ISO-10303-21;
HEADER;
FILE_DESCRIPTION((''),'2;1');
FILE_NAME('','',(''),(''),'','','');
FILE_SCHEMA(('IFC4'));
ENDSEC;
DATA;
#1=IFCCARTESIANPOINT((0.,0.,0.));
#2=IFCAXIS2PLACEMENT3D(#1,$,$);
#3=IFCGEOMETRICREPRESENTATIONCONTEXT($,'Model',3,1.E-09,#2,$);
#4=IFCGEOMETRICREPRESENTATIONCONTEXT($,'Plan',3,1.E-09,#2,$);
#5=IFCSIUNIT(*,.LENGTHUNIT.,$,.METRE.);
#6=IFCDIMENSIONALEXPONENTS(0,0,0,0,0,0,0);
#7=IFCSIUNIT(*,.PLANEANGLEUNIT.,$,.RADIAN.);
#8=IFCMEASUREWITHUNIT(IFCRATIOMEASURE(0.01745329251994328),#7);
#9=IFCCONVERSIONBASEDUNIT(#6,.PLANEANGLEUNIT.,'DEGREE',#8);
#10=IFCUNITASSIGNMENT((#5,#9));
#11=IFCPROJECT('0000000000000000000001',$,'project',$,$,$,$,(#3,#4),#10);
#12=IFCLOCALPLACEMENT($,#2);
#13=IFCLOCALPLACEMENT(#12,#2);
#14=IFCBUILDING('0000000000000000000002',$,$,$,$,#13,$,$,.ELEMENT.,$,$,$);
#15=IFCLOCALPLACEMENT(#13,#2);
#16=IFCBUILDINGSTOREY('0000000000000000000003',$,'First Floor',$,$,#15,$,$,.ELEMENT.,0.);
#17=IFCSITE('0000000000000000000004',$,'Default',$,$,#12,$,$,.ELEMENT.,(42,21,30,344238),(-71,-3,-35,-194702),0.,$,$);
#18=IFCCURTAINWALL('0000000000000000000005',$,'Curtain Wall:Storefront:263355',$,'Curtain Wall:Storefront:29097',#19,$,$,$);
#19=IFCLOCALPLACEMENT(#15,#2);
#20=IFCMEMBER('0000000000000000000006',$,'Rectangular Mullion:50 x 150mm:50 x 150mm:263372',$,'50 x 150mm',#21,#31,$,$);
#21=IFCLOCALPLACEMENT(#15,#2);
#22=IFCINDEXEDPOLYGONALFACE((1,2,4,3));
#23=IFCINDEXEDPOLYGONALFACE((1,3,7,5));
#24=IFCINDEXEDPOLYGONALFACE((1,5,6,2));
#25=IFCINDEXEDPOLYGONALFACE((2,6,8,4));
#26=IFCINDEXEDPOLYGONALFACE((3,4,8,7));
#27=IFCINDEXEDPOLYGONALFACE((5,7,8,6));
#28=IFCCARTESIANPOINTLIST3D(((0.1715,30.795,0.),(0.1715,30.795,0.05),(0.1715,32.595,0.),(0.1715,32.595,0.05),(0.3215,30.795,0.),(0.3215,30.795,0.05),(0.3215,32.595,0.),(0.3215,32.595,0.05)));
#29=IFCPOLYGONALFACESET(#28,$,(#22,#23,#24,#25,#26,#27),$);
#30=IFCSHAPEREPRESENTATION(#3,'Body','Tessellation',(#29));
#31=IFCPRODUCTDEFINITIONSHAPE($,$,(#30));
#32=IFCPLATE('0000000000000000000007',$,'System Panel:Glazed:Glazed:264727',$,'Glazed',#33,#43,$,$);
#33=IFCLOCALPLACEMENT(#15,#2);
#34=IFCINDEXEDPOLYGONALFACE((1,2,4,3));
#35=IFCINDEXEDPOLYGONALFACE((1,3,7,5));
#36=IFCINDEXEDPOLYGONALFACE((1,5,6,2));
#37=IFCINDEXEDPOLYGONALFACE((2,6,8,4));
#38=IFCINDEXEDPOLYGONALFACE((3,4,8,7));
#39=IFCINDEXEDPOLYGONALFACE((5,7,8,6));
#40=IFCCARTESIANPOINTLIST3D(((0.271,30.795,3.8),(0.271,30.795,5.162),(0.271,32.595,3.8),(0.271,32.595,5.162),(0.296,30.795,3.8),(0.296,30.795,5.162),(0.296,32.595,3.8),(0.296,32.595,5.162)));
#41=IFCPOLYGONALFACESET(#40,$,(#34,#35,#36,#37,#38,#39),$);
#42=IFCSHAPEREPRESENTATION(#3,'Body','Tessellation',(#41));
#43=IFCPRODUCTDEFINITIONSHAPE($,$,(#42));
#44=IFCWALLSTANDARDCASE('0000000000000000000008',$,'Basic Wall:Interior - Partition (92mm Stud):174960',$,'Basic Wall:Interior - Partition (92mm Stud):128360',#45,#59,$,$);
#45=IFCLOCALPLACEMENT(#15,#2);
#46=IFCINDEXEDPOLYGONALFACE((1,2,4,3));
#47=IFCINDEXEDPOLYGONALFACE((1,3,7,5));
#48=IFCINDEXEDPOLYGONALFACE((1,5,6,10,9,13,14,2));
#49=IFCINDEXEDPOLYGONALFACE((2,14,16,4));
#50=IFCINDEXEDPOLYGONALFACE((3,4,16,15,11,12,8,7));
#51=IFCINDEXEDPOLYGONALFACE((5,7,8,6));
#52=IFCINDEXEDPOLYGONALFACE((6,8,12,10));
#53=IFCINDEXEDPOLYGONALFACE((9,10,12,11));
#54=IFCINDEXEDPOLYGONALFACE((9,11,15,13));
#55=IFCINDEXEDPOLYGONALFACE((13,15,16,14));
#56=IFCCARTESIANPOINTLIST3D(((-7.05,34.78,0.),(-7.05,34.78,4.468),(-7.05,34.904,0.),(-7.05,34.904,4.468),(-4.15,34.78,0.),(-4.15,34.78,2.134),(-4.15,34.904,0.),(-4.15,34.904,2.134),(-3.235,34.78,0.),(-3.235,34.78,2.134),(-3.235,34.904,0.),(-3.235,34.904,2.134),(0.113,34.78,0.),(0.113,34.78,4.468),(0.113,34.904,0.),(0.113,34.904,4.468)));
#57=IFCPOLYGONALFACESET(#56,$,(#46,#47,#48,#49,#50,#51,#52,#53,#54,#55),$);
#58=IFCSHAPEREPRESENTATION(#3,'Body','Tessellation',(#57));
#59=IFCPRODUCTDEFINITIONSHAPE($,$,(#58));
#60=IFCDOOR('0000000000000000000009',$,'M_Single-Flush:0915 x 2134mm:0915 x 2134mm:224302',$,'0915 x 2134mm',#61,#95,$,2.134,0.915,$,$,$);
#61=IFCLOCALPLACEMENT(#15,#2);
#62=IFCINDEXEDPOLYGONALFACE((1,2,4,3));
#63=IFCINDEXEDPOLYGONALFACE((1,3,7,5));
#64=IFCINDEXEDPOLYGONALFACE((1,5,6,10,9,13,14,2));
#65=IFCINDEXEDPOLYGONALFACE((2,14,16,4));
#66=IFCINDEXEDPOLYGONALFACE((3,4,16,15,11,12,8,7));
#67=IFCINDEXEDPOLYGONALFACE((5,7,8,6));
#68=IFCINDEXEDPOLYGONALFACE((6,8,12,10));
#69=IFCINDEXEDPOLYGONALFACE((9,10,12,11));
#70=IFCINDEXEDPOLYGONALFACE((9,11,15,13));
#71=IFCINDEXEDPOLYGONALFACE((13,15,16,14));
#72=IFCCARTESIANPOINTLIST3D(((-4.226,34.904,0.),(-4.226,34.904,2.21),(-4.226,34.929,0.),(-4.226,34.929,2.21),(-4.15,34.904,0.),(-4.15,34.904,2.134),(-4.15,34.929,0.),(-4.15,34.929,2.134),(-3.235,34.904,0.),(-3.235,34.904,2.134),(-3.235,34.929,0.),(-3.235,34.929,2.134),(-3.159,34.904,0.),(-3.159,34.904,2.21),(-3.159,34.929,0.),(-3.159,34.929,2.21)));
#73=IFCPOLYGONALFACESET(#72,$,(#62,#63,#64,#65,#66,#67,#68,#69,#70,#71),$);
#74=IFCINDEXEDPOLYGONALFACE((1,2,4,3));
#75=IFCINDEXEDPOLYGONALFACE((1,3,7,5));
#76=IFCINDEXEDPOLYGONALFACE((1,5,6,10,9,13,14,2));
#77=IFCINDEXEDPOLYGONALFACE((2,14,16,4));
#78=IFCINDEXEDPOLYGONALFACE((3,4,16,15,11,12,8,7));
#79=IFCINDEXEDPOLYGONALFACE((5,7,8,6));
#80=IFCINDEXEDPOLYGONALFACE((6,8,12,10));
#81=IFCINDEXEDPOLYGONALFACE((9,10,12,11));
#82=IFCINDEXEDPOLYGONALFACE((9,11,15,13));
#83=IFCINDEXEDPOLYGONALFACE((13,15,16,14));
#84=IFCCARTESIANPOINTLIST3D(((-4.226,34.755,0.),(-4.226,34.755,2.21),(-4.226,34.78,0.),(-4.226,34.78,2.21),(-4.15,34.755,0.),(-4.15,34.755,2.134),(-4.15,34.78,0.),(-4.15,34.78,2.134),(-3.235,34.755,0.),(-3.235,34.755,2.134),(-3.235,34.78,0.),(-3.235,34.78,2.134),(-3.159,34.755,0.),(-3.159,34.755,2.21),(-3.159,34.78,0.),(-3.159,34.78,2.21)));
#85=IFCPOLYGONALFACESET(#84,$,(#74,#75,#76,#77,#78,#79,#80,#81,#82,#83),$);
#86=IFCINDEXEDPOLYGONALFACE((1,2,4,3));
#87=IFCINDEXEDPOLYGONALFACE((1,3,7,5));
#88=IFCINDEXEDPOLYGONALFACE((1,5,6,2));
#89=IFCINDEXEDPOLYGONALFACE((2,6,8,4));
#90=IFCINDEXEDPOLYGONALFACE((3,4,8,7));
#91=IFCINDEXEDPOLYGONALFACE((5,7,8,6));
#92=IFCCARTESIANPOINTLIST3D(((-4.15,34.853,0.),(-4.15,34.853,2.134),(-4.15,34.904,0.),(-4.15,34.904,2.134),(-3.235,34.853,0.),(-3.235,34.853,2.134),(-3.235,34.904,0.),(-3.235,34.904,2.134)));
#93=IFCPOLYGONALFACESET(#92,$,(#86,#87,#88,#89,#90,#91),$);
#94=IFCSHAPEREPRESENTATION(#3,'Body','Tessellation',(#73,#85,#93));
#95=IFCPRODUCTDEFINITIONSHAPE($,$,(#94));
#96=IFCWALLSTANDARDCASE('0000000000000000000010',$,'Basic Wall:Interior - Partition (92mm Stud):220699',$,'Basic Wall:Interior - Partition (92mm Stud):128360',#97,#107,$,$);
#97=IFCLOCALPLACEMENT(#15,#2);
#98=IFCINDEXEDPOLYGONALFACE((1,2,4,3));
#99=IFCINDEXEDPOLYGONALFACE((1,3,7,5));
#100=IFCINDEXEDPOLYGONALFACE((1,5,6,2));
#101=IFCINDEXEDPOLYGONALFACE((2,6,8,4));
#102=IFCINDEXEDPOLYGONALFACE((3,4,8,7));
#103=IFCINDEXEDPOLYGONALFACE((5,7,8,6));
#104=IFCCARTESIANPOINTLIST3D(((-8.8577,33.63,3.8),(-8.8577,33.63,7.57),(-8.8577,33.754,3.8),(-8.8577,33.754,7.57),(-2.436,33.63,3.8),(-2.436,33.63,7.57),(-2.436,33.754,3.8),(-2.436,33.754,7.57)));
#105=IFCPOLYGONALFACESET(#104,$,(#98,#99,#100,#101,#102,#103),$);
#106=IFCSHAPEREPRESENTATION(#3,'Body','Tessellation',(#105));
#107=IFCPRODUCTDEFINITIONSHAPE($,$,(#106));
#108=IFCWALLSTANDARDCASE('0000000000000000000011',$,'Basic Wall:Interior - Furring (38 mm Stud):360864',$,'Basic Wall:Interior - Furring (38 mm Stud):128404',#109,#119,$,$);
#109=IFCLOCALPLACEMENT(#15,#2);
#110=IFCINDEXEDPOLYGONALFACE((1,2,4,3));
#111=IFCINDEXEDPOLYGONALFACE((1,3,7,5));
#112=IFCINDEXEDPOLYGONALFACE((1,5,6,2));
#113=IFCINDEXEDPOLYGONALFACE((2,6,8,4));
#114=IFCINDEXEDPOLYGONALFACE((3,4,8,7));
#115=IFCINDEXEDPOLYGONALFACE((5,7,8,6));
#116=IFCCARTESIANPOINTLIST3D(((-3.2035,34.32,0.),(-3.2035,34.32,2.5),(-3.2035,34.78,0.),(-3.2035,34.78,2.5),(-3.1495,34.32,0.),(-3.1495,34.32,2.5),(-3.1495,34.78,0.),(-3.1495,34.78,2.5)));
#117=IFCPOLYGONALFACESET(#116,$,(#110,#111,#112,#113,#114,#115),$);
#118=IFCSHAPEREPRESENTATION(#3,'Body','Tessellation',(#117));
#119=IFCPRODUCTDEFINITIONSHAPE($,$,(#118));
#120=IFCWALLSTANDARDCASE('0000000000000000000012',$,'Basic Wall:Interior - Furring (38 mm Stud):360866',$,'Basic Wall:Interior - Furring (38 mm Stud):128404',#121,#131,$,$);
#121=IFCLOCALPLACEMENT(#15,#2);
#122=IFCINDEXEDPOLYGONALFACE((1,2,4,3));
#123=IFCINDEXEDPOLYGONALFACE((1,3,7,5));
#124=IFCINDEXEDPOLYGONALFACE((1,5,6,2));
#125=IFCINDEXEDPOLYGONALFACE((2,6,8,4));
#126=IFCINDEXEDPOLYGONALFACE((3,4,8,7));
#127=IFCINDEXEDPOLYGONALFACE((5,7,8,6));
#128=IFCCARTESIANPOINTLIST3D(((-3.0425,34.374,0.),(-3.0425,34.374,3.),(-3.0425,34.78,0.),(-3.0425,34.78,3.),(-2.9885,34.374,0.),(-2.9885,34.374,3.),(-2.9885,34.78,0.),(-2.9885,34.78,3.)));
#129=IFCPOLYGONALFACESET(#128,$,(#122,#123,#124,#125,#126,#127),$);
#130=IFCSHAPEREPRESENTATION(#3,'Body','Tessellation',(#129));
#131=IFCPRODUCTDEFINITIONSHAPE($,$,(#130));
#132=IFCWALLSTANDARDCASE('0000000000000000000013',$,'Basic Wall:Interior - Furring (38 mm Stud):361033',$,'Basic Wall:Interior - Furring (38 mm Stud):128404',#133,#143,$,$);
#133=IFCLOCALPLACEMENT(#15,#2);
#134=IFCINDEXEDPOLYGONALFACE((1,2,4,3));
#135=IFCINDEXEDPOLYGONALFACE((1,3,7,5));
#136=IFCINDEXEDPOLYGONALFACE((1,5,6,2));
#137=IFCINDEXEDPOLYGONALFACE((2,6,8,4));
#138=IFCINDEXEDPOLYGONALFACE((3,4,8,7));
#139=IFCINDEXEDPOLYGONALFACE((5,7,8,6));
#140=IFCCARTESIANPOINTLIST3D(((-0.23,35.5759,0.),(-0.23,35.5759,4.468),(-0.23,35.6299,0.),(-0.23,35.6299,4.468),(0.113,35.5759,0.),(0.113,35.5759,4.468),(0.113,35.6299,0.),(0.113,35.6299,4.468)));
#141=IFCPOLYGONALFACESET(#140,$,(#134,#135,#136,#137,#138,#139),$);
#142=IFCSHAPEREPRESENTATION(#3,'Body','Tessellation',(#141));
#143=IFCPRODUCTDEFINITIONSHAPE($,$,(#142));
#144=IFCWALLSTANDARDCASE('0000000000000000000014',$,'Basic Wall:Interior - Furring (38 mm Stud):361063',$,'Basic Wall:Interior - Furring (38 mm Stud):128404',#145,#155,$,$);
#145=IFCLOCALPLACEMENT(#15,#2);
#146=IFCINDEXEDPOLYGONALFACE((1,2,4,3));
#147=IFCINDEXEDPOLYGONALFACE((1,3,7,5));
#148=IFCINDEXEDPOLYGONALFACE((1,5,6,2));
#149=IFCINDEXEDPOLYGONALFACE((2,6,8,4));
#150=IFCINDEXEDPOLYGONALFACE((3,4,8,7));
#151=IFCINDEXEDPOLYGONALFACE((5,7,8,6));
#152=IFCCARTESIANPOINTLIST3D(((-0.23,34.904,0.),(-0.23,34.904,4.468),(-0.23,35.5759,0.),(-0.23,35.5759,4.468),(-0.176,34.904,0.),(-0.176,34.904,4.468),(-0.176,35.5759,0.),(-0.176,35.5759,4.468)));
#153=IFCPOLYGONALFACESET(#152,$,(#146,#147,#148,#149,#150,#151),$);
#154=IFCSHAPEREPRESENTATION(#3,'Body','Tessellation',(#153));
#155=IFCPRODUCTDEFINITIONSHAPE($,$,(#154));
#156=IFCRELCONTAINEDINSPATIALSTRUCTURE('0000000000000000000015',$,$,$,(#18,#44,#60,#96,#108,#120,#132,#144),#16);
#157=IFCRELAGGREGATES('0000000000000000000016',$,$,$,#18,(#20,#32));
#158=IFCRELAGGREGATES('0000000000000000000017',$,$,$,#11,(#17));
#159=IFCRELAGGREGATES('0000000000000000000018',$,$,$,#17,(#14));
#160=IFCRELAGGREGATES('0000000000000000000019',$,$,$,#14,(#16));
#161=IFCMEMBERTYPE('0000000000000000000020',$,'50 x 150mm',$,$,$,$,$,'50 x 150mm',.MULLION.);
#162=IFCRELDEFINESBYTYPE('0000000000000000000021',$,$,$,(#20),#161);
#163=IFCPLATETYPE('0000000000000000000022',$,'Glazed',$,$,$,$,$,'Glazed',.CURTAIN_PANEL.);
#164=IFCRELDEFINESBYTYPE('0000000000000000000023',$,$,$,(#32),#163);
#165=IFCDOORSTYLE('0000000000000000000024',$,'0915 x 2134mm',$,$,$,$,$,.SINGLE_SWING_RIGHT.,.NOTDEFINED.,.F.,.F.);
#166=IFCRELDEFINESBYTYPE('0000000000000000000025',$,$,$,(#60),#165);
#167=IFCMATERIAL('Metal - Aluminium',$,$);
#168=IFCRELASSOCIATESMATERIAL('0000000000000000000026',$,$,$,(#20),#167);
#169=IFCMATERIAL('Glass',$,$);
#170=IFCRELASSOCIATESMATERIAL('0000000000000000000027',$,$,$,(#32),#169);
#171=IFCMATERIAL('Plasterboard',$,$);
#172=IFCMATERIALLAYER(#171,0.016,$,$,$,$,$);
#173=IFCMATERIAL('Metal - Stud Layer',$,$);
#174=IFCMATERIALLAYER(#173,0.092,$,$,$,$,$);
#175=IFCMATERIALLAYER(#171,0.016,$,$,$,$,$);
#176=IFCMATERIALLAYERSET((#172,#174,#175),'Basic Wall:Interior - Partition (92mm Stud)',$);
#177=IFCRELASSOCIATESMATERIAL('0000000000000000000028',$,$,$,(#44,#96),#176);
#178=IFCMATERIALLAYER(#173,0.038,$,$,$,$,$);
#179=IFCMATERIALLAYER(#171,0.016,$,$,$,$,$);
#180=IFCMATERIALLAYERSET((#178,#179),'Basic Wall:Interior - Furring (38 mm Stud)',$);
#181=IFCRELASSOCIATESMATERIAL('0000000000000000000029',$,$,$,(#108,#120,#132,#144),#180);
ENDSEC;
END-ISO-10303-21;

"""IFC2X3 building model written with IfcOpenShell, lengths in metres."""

from ifc_helpers import new_model, entity, si_unit, converted_unit, frame, frame_2d, origin, origin_2d_with_axis, place, context, project, spatial, polyline, rectangle, outline, extrude, source, transform, mapped, material, layer, layer_set, layer_usage, type_object, type_shapes, element, fill, aggregate, save


model = new_model("IFC2X3")

# Units and contexts
model_context = context("Model", 3, precision=1e-09, world=origin())
plan_context = context("Plan", 3, precision=1e-09, world=origin())
ifc_project = project(units=[si_unit("LENGTHUNIT", "METRE"), converted_unit("PLANEANGLEUNIT", "DEGREE", entity("IfcRatioMeasure", 0.01745329251994328), si_unit("PLANEANGLEUNIT", "RADIAN"), dimensions=[0, 0, 0, 0, 0, 0, 0])], contexts=[model_context, plan_context])

# Site, building, storey
site_placement = place(None, origin())
site = spatial("IfcSite", under=ifc_project, at=site_placement, Name="Default", CompositionType="ELEMENT", RefLatitude=(42, 21, 30, 344238), RefLongitude=(-71, -3, -35, -194702), RefElevation=0.0)
building_placement = place(site_placement, origin())
building = spatial("IfcBuilding", under=site, at=building_placement, CompositionType="ELEMENT")
storey_placement = place(building_placement, origin())
storey = spatial("IfcBuildingStorey", under=building, at=storey_placement, Name="First Floor", CompositionType="ELEMENT", Elevation=0.0)

# Curtain wall, member, plate
curtain_wall_placement = place(storey_placement, origin())
curtain_wall = element("IfcCurtainWall", 1, at=curtain_wall_placement, inside=storey, Name="Curtain Wall:Storefront:263355", ObjectType="Curtain Wall:Storefront:29097")
ifc_material_1 = material(Name="Metal - Aluminium")
member_type_1 = type_object("IfcMemberType", Name="50 x 150mm", ElementType="50 x 150mm", PredefinedType="MULLION")
shared_shape_1 = source(origin(), model_context, "Body", "SweptSolid", [
    extrude(rectangle(XDim=0.05, YDim=0.15, at=origin_2d_with_axis()), frame((-0.025, 0.0, -1.8), z_axis=(0.0, 0.0, 1.0), x_axis=(-1.0, 0.0, 0.0)), (0.0, 0.0, 1.0), 1.8),
])
type_shapes(member_type_1, [shared_shape_1])
member_1_placement = place(storey_placement, frame((0.2465, 32.595, 0.0), z_axis=(0.0, 1.0, 0.0), x_axis=(0.0, 0.0, -1.0)))
member_1 = element("IfcMember", 2, at=member_1_placement, type_object=member_type_1, material=ifc_material_1, Name="Rectangular Mullion:50 x 150mm:50 x 150mm:263372", ObjectType="50 x 150mm", context=model_context, shape_type="MappedRepresentation", body=[
    mapped(shared_shape_1, transform((0.0, 0.0, 0.0), scale=1.0)),
])
ifc_material_2 = material(Name="Glass")
plate_type_1 = type_object("IfcPlateType", Name="Glazed", ElementType="Glazed", PredefinedType="CURTAIN_PANEL")
shared_shape_2 = source(origin(), model_context, "Body", "SweptSolid", [
    extrude(rectangle(XDim=1.362, YDim=0.025, at=frame_2d((0.0, 0.0), x_axis=(0.0, 1.0))), frame((-0.9, 0.037, 0.681), z_axis=(1.0, 0.0, 0.0), x_axis=(0.0, 1.0, 0.0)), (0.0, 0.0, 1.0), 1.8),
])
type_shapes(plate_type_1, [shared_shape_2])
plate_1_placement = place(storey_placement, frame((0.2465, 31.695, 3.8), z_axis=(0.0, 0.0, 1.0), x_axis=(0.0, -1.0, 0.0)))
plate_1 = element("IfcPlate", 3, at=plate_1_placement, type_object=plate_type_1, material=ifc_material_2, Name="System Panel:Glazed:Glazed:264727", ObjectType="Glazed", context=model_context, shape_type="MappedRepresentation", body=[
    mapped(shared_shape_2, transform((0.0, 0.0, 0.0), scale=1.0)),
])
aggregate(curtain_wall, [member_1, plate_1])

# Wall, opening, door
ifc_material_3 = material(Name="Plasterboard")
ifc_layer_1 = layer(ifc_material_3, 0.016)
ifc_material_4 = material(Name="Metal - Stud Layer")
ifc_layer_2 = layer(ifc_material_4, 0.092)
ifc_layer_3 = layer(ifc_material_3, 0.016)
ifc_layer_set_1 = layer_set([ifc_layer_1, ifc_layer_2, ifc_layer_3], Name="Basic Wall:Interior - Partition (92mm Stud)")
ifc_layer_usage_1 = layer_usage(ifc_layer_set_1, "AXIS2", "NEGATIVE", 0.062)
wall_1_placement = place(storey_placement, frame((0.113, 34.842, 0.0), z_axis=(0.0, 0.0, 1.0), x_axis=(-1.0, 0.0, 0.0)))
wall_1 = element("IfcWallStandardCase", 4, at=wall_1_placement, inside=storey, material=ifc_layer_usage_1, Name="Basic Wall:Interior - Partition (92mm Stud):174960", ObjectType="Basic Wall:Interior - Partition (92mm Stud):128360", context=model_context, shape_type="SweptSolid", body=[
    extrude(rectangle(XDim=7.163, YDim=0.124, at=frame_2d((3.5815, 0.0), x_axis=(-1.0, 0.0))), origin(), (0.0, 0.0, 1.0), 4.468),
])
opening_placement = place(wall_1_placement, frame((4.263, 0.062, 0.0)))
opening = element("IfcOpeningElement", 5, at=opening_placement, cuts=wall_1, ObjectType="Opening", context=model_context, shape_type="SweptSolid", body=[
    extrude(rectangle(XDim=0.915, YDim=2.134, at=frame_2d((1.067, 0.4575), x_axis=(0.0, 1.0))), frame((0.0, 0.0, 0.0), z_axis=(0.0, -1.0, 0.0), x_axis=(0.0, 0.0, 1.0)), (0.0, 0.0, 1.0), 0.124),
])
door_style = type_object("IfcDoorStyle", Name="0915 x 2134mm", ConstructionType="NOTDEFINED", OperationType="SINGLE_SWING_RIGHT", ParameterTakesPrecedence=False, Sizeable=False)
shared_shape_3 = source(origin(), model_context, "Body", "SweptSolid", [
    extrude(outline(polyline([(-0.5335, -1.124), (0.5335, -1.124), (0.5335, 1.086), (0.4575, 1.086), (0.4575, -1.048), (-0.4575, -1.048), (-0.4575, 1.086), (-0.5335, 1.086), (-0.5335, -1.124)])), frame((0.4575, 0.124, 1.086), z_axis=(0.0, 1.0, 0.0), x_axis=(1.0, 0.0, 0.0)), (0.0, 0.0, 1.0), 0.025),
    extrude(outline(polyline([(-1.124, -0.5335), (1.086, -0.5335), (1.086, -0.4575), (-1.048, -0.4575), (-1.048, 0.4575), (1.086, 0.4575), (1.086, 0.5335), (-1.124, 0.5335), (-1.124, -0.5335)])), frame((0.4575, -0.025, 1.086), z_axis=(0.0, 1.0, 0.0), x_axis=(0.0, 0.0, -1.0)), (0.0, 0.0, 1.0), 0.025),
    extrude(rectangle(XDim=0.051, YDim=0.915, at=origin_2d_with_axis()), frame((0.4575, 0.0985, 0.0), z_axis=(0.0, 0.0, 1.0), x_axis=(0.0, 1.0, 0.0)), (0.0, 0.0, 1.0), 2.134),
])
type_shapes(door_style, [shared_shape_3])
door_placement = place(opening_placement, frame((0.0, 0.0, 0.0), z_axis=(0.0, 0.0, 1.0), x_axis=(-1.0, 0.0, 0.0)))
door = element("IfcDoor", 6, at=door_placement, inside=storey, type_object=door_style, Name="M_Single-Flush:0915 x 2134mm:0915 x 2134mm:224302", ObjectType="0915 x 2134mm", OverallHeight=2.134, OverallWidth=0.915, context=model_context, shape_type="MappedRepresentation", body=[
    mapped(shared_shape_3, transform((0.0, 0.0, 0.0), scale=1.0)),
])
fill(opening, door)

# Walls
wall_2_placement = place(storey_placement, frame((-2.436, 33.692, 3.8), z_axis=(0.0, 0.0, 1.0), x_axis=(-1.0, 0.0, 0.0)))
element("IfcWallStandardCase", 7, at=wall_2_placement, inside=storey, material=ifc_layer_usage_1, Name="Basic Wall:Interior - Partition (92mm Stud):220699", ObjectType="Basic Wall:Interior - Partition (92mm Stud):128360", context=model_context, shape_type="SweptSolid", body=[
    extrude(rectangle(XDim=6.4217, YDim=0.124, at=frame_2d((3.2109, 0.0), x_axis=(-1.0, 0.0))), origin(), (0.0, 0.0, 1.0), 3.77),
])
ifc_layer_4 = layer(ifc_material_4, 0.038)
ifc_layer_5 = layer(ifc_material_3, 0.016)
ifc_layer_set_2 = layer_set([ifc_layer_4, ifc_layer_5], Name="Basic Wall:Interior - Furring (38 mm Stud)")
ifc_layer_usage_2 = layer_usage(ifc_layer_set_2, "AXIS2", "NEGATIVE", 0.027)
wall_3_placement = place(storey_placement, frame((-3.1765, 34.78, 0.0), z_axis=(0.0, 0.0, 1.0), x_axis=(0.0, -1.0, 0.0)))
element("IfcWallStandardCase", 8, at=wall_3_placement, inside=storey, material=ifc_layer_usage_2, Name="Basic Wall:Interior - Furring (38 mm Stud):360864", ObjectType="Basic Wall:Interior - Furring (38 mm Stud):128404", context=model_context, shape_type="SweptSolid", body=[
    extrude(rectangle(XDim=0.46, YDim=0.054, at=frame_2d((0.23, 0.0), x_axis=(-1.0, 0.0))), origin(), (0.0, 0.0, 1.0), 2.5),
])
wall_4_placement = place(storey_placement, frame((-3.0155, 34.374, 0.0), z_axis=(0.0, 0.0, 1.0), x_axis=(0.0, 1.0, 0.0)))
element("IfcWallStandardCase", 9, at=wall_4_placement, inside=storey, material=ifc_layer_usage_2, Name="Basic Wall:Interior - Furring (38 mm Stud):360866", ObjectType="Basic Wall:Interior - Furring (38 mm Stud):128404", context=model_context, shape_type="SweptSolid", body=[
    extrude(rectangle(XDim=0.406, YDim=0.054, at=frame_2d((0.203, 0.0), x_axis=(-1.0, 0.0))), origin(), (0.0, 0.0, 1.0), 3.0),
])
wall_5_placement = place(storey_placement, frame((0.113, 35.6029, 0.0), z_axis=(0.0, 0.0, 1.0), x_axis=(-1.0, 0.0, 0.0)))
element("IfcWallStandardCase", 10, at=wall_5_placement, inside=storey, material=ifc_layer_usage_2, Name="Basic Wall:Interior - Furring (38 mm Stud):361033", ObjectType="Basic Wall:Interior - Furring (38 mm Stud):128404", context=model_context, shape_type="SweptSolid", body=[
    extrude(rectangle(XDim=0.343, YDim=0.054, at=frame_2d((0.1715, 0.0), x_axis=(-1.0, 0.0))), origin(), (0.0, 0.0, 1.0), 4.468),
])
wall_6_placement = place(storey_placement, frame((-0.203, 35.5759, 0.0), z_axis=(0.0, 0.0, 1.0), x_axis=(0.0, -1.0, 0.0)))
element("IfcWallStandardCase", 11, at=wall_6_placement, inside=storey, material=ifc_layer_usage_2, Name="Basic Wall:Interior - Furring (38 mm Stud):361063", ObjectType="Basic Wall:Interior - Furring (38 mm Stud):128404", context=model_context, shape_type="SweptSolid", body=[
    extrude(rectangle(XDim=0.6719, YDim=0.054, at=frame_2d((0.336, 0.0), x_axis=(-1.0, 0.0))), origin(), (0.0, 0.0, 1.0), 4.468),
])

save(model, "model.ifc")
